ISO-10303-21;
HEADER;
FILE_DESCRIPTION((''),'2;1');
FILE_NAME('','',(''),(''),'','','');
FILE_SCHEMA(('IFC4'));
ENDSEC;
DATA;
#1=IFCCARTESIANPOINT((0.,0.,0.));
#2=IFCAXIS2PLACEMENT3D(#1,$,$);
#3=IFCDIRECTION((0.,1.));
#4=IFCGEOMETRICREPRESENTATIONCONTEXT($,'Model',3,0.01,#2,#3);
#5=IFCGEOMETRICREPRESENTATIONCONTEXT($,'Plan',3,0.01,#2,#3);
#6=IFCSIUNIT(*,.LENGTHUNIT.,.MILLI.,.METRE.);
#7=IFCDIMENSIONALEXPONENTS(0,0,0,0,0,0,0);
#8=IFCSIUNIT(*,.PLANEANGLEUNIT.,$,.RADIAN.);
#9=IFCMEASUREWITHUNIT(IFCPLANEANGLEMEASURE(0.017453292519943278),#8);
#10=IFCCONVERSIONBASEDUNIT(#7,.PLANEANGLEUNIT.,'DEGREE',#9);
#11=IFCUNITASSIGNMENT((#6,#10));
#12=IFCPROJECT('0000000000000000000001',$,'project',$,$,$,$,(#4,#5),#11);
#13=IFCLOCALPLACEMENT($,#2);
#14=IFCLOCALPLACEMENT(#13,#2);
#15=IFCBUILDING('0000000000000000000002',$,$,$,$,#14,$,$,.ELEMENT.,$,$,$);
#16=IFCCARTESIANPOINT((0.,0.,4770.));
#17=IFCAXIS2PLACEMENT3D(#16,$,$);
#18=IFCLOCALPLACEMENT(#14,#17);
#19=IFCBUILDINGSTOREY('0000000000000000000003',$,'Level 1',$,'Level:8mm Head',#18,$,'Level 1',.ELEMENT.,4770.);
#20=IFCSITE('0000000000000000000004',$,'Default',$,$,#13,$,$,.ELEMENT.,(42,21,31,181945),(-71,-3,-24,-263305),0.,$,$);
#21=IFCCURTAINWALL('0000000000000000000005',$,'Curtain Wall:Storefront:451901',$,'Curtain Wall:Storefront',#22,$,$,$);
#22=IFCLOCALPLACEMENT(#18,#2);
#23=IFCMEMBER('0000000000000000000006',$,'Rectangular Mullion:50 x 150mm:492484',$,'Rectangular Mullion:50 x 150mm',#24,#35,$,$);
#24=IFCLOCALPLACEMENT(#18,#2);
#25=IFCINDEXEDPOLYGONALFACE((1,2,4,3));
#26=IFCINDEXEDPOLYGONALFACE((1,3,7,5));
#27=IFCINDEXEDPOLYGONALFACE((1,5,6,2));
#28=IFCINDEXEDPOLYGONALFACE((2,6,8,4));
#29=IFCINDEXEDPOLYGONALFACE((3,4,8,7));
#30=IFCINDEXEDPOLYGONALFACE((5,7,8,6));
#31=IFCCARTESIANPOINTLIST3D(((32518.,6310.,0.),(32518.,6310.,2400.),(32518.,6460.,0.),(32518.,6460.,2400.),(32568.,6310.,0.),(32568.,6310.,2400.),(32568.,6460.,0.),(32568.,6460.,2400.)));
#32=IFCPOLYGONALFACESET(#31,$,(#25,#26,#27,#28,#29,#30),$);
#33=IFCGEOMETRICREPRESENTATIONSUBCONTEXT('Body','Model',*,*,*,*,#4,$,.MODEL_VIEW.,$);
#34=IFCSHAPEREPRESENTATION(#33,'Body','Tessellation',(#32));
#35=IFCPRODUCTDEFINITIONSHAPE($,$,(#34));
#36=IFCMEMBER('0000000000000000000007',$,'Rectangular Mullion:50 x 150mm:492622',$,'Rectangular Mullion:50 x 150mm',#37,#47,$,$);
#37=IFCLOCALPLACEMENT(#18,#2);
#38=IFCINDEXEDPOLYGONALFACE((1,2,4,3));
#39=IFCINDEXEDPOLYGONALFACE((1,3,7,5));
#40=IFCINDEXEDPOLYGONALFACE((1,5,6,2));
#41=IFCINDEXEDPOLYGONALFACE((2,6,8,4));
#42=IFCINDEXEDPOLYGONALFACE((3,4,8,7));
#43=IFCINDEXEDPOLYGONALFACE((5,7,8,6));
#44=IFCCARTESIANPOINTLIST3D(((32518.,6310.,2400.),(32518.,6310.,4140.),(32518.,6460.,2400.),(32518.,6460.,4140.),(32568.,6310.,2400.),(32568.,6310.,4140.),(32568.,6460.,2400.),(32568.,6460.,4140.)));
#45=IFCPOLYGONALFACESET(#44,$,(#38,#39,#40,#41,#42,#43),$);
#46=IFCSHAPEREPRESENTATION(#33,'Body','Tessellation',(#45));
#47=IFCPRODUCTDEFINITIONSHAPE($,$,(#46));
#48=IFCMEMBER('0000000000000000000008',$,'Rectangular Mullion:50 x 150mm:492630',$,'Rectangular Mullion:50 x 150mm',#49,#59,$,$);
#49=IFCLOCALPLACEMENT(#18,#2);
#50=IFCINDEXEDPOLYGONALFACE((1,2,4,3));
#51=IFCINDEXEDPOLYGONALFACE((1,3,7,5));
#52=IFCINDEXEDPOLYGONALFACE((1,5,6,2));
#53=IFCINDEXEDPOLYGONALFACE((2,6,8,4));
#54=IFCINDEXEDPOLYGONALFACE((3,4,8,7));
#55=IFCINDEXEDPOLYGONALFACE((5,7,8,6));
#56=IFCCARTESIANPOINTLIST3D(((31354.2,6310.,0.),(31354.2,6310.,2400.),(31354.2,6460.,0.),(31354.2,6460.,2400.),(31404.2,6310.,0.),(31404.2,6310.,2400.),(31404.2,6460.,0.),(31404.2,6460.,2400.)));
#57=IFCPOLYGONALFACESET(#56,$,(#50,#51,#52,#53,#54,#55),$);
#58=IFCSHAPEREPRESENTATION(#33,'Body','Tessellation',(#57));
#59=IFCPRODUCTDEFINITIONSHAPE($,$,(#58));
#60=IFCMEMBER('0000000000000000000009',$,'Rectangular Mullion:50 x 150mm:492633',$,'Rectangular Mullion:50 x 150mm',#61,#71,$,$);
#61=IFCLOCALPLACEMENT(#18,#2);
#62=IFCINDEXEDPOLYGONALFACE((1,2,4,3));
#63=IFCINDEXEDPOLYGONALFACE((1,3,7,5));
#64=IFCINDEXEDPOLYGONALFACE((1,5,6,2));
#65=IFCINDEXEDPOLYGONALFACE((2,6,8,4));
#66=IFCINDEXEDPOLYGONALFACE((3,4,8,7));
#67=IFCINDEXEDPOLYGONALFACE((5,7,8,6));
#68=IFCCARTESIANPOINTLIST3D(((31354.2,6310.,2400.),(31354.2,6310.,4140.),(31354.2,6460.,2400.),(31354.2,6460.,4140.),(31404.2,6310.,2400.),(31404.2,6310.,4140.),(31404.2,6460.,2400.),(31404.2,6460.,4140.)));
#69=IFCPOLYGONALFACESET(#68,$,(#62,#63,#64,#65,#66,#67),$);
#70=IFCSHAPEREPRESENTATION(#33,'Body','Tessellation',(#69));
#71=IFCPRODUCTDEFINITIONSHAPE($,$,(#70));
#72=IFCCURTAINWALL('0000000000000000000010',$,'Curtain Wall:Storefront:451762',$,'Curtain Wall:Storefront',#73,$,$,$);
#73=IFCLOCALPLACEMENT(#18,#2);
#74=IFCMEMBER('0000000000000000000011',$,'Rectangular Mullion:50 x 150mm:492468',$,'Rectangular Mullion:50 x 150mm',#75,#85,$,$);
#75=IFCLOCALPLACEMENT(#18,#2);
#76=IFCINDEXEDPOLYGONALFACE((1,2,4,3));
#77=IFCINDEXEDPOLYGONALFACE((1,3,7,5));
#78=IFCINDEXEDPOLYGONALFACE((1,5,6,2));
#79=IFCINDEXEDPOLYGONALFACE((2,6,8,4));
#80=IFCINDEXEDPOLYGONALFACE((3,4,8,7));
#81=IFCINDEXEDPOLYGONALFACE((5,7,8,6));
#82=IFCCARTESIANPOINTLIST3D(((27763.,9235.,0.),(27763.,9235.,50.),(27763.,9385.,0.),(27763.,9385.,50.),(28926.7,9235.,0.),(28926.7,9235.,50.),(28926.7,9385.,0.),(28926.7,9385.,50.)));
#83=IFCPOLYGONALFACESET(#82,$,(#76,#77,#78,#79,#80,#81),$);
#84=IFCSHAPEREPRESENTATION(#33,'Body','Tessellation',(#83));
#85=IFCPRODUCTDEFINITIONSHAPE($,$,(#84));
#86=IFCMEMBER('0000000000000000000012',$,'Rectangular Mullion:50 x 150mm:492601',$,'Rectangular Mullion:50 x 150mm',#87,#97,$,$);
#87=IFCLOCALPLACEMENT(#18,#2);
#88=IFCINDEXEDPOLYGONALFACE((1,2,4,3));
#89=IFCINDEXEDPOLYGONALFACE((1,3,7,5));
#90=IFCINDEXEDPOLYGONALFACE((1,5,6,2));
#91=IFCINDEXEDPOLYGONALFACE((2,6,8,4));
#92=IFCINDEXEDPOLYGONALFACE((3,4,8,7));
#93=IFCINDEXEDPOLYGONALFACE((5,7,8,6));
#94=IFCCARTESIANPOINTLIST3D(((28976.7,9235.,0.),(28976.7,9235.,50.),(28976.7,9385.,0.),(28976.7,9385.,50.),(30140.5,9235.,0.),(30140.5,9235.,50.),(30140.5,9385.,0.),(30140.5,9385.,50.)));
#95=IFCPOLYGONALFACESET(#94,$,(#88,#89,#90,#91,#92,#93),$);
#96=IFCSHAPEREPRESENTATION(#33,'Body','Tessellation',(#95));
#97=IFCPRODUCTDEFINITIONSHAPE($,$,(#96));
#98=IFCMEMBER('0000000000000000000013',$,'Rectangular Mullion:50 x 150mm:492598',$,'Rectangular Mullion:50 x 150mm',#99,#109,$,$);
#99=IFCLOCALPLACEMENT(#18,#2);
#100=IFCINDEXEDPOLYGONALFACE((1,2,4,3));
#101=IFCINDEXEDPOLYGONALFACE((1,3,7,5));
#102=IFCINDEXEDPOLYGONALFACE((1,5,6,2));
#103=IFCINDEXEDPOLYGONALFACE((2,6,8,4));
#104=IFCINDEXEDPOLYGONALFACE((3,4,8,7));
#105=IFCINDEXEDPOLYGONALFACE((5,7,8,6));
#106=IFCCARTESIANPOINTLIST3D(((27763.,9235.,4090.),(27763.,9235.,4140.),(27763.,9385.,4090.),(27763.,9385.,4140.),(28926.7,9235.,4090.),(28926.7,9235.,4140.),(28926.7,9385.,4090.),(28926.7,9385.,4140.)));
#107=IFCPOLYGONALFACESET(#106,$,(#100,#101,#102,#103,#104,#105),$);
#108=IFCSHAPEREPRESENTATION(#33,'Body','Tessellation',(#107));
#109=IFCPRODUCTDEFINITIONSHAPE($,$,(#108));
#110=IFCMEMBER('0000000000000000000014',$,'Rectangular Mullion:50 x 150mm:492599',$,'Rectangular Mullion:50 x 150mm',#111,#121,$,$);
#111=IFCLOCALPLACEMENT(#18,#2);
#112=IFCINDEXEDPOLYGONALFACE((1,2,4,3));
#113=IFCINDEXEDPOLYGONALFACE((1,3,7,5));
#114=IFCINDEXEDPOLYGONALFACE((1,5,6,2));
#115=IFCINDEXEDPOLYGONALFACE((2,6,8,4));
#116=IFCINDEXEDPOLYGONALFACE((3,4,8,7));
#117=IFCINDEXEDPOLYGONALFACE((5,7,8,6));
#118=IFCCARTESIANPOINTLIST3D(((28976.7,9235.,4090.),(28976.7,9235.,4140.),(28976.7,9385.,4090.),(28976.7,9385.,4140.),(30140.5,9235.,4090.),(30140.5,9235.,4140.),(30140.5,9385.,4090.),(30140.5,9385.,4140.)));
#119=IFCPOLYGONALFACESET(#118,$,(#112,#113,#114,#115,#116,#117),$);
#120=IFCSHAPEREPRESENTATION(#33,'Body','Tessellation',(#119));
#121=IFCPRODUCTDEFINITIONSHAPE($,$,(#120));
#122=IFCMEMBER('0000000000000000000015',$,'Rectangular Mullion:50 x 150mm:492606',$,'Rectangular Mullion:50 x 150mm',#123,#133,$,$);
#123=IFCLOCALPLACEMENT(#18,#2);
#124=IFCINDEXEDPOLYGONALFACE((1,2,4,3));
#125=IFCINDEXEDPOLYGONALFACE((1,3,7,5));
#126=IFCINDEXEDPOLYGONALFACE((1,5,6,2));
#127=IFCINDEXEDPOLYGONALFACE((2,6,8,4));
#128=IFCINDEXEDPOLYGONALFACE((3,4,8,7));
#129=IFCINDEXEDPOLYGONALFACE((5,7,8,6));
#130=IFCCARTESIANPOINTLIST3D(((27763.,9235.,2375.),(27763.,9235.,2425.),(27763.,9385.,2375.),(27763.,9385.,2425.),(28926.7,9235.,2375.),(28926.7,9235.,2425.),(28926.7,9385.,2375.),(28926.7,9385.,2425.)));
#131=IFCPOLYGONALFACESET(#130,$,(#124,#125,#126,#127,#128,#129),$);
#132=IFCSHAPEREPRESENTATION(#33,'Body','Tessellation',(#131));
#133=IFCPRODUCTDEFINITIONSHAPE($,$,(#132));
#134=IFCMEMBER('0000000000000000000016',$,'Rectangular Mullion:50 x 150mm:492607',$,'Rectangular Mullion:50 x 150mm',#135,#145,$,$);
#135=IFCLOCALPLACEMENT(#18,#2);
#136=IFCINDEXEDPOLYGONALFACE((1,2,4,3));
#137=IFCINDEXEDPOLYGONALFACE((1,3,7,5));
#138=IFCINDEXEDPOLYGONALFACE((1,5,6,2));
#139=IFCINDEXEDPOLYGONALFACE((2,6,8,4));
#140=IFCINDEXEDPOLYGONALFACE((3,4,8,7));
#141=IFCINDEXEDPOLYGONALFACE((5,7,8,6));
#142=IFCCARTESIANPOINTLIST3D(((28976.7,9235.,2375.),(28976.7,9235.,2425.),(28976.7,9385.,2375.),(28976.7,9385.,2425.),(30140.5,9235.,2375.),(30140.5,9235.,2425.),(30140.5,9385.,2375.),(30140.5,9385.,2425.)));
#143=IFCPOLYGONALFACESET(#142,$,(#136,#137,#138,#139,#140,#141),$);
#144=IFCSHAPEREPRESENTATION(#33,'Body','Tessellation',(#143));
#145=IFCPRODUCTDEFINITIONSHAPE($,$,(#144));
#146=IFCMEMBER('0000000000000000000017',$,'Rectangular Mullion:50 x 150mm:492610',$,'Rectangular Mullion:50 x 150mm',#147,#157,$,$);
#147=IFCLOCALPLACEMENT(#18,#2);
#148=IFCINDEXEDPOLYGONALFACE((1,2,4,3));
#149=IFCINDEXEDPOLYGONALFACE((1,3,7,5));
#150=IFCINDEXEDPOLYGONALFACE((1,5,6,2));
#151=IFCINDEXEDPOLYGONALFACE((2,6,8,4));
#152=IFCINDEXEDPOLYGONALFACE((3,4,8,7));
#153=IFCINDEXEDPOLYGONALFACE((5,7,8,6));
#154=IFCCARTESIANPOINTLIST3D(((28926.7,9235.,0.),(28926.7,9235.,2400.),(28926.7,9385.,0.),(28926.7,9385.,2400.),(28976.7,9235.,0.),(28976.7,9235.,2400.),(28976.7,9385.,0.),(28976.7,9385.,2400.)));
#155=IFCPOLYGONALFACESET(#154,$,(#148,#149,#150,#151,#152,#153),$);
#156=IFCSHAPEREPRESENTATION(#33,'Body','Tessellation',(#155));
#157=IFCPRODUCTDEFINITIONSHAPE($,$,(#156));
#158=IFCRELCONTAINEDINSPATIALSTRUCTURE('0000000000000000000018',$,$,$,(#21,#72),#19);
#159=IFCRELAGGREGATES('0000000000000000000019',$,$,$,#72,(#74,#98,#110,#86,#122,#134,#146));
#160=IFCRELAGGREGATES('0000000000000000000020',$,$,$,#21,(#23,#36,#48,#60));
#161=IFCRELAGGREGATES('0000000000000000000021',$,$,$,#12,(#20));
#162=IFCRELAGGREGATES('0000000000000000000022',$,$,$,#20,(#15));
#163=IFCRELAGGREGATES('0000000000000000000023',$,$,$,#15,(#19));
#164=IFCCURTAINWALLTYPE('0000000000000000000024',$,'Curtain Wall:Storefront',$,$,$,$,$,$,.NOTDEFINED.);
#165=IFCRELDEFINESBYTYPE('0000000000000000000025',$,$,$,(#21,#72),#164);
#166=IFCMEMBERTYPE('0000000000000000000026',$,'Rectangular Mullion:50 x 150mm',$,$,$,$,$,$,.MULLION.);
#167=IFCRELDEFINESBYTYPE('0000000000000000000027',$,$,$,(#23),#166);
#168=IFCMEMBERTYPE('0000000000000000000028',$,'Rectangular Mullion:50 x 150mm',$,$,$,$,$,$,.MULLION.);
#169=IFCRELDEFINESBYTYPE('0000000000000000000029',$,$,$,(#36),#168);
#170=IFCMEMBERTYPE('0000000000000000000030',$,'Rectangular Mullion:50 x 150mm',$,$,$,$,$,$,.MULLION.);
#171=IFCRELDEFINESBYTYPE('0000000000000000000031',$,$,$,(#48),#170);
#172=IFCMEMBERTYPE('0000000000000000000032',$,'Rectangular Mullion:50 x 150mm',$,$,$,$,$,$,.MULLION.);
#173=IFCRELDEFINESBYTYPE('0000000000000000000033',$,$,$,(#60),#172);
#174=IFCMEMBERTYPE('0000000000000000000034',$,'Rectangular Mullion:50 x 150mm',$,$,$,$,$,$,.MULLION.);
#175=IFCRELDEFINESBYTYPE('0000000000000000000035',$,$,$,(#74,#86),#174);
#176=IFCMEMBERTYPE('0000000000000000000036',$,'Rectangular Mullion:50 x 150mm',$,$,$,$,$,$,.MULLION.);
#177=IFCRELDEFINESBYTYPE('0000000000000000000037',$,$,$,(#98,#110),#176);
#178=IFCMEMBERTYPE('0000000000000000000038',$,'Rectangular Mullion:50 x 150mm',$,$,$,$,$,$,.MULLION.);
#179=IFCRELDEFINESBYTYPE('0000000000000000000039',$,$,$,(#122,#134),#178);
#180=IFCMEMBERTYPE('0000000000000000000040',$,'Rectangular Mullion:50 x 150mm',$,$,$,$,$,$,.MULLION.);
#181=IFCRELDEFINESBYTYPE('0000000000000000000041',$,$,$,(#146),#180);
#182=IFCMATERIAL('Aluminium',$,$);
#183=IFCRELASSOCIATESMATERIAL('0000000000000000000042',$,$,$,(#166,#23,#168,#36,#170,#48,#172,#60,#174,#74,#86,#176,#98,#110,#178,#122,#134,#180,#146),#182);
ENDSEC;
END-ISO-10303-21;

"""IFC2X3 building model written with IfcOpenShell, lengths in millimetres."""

from ifc_helpers import new_model, entity, si_unit, converted_unit, direction, frame, origin, origin_2d_with_axis, place, context, subcontext, project, spatial, rectangle, extrude, source, transform, mapped, material, type_object, type_shapes, element, aggregate, save


model = new_model("IFC2X3")

# Units and contexts
model_context = context("Model", 3, precision=0.01, world=origin(), true_north=direction((0.0, 1.0)))
plan_context = context("Plan", 3, precision=0.01, world=origin(), true_north=direction((0.0, 1.0)))
body_context = subcontext(model_context, "Body", "Model", "MODEL_VIEW")
ifc_project = project(units=[si_unit("LENGTHUNIT", "METRE", prefix="MILLI"), converted_unit("PLANEANGLEUNIT", "DEGREE", entity("IfcPlaneAngleMeasure", 0.017453292519943278), si_unit("PLANEANGLEUNIT", "RADIAN"), dimensions=[0, 0, 0, 0, 0, 0, 0])], contexts=[model_context, plan_context])

# Site, building, storey
site_placement = place(None, origin())
site = spatial("IfcSite", under=ifc_project, at=site_placement, Name="Default", CompositionType="ELEMENT", RefLatitude=(42, 21, 31, 181945), RefLongitude=(-71, -3, -24, -263305), RefElevation=0.0)
building_placement = place(site_placement, origin())
building = spatial("IfcBuilding", under=site, at=building_placement, CompositionType="ELEMENT")
storey_placement = place(building_placement, frame((0.0, 0.0, 4770.0)))
storey = spatial("IfcBuildingStorey", under=building, at=storey_placement, Name="Level 1", ObjectType="Level:8mm Head", LongName="Level 1", CompositionType="ELEMENT", Elevation=4770.0)

# Curtain walls, members
curtain_wall_type = type_object("IfcCurtainWallType", Name="Curtain Wall:Storefront", PredefinedType="NOTDEFINED")
curtain_wall_1_placement = place(storey_placement, frame((0.0, 0.0, -4770.0)))
curtain_wall_1 = element("IfcCurtainWall", 1, at=curtain_wall_1_placement, inside=storey, type_object=curtain_wall_type, Name="Curtain Wall:Storefront:451901", ObjectType="Curtain Wall:Storefront")
ifc_material_1 = material(Name="Aluminium")
member_type_1 = type_object("IfcMemberType", Name="Rectangular Mullion:50 x 150mm", PredefinedType="MULLION", material=ifc_material_1)
shared_shape_1 = source(origin(), body_context, "Body", "SweptSolid", [
    extrude(rectangle(XDim=50.0, YDim=150.0, at=origin_2d_with_axis()), frame((-25.0, 0.0, -2400.0), z_axis=(0.0, 0.0, 1.0), x_axis=(-1.0, 0.0, 0.0)), (0.0, 0.0, 1.0), 2400.0),
])
type_shapes(member_type_1, [shared_shape_1])
member_1_placement = place(curtain_wall_1_placement, frame((32568.0, 6385.0, 4770.0), z_axis=(0.0, 0.0, -1.0), x_axis=(1.0, 0.0, 0.0)))
member_1 = element("IfcMember", 2, at=member_1_placement, type_object=member_type_1, material=ifc_material_1, Name="Rectangular Mullion:50 x 150mm:492484", ObjectType="Rectangular Mullion:50 x 150mm", context=body_context, shape_type="MappedRepresentation", body=[
    mapped(shared_shape_1, transform((0.0, 0.0, 0.0), scale=1.0)),
])
member_type_2 = type_object("IfcMemberType", Name="Rectangular Mullion:50 x 150mm", PredefinedType="MULLION", material=ifc_material_1)
shared_shape_2 = source(origin(), body_context, "Body", "SweptSolid", [
    extrude(rectangle(XDim=50.0, YDim=150.0, at=origin_2d_with_axis()), frame((-25.0, 0.0, -1740.0), z_axis=(0.0, 0.0, 1.0), x_axis=(-1.0, 0.0, 0.0)), (0.0, 0.0, 1.0), 1740.0),
])
type_shapes(member_type_2, [shared_shape_2])
member_2_placement = place(curtain_wall_1_placement, frame((32568.0, 6385.0, 7170.0), z_axis=(0.0, 0.0, -1.0), x_axis=(1.0, 0.0, 0.0)))
member_2 = element("IfcMember", 3, at=member_2_placement, type_object=member_type_2, material=ifc_material_1, Name="Rectangular Mullion:50 x 150mm:492622", ObjectType="Rectangular Mullion:50 x 150mm", context=body_context, shape_type="MappedRepresentation", body=[
    mapped(shared_shape_2, transform((0.0, 0.0, 0.0), scale=1.0)),
])
member_type_3 = type_object("IfcMemberType", Name="Rectangular Mullion:50 x 150mm", PredefinedType="MULLION", material=ifc_material_1)
shared_shape_3 = source(origin(), body_context, "Body", "SweptSolid", [
    extrude(rectangle(XDim=50.0, YDim=150.0, at=origin_2d_with_axis()), frame((0.0, 0.0, -2400.0), z_axis=(0.0, 0.0, 1.0), x_axis=(-1.0, 0.0, 0.0)), (0.0, 0.0, 1.0), 2400.0),
])
type_shapes(member_type_3, [shared_shape_3])
member_3_placement = place(curtain_wall_1_placement, frame((31379.2, 6385.0, 4770.0), z_axis=(0.0, 0.0, -1.0), x_axis=(1.0, 0.0, 0.0)))
member_3 = element("IfcMember", 4, at=member_3_placement, type_object=member_type_3, material=ifc_material_1, Name="Rectangular Mullion:50 x 150mm:492630", ObjectType="Rectangular Mullion:50 x 150mm", context=body_context, shape_type="MappedRepresentation", body=[
    mapped(shared_shape_3, transform((0.0, 0.0, 0.0), scale=1.0)),
])
member_type_4 = type_object("IfcMemberType", Name="Rectangular Mullion:50 x 150mm", PredefinedType="MULLION", material=ifc_material_1)
shared_shape_4 = source(origin(), body_context, "Body", "SweptSolid", [
    extrude(rectangle(XDim=50.0, YDim=150.0, at=origin_2d_with_axis()), frame((0.0, 0.0, -1740.0), z_axis=(0.0, 0.0, 1.0), x_axis=(-1.0, 0.0, 0.0)), (0.0, 0.0, 1.0), 1740.0),
])
type_shapes(member_type_4, [shared_shape_4])
member_4_placement = place(curtain_wall_1_placement, frame((31379.2, 6385.0, 7170.0), z_axis=(0.0, 0.0, -1.0), x_axis=(1.0, 0.0, 0.0)))
member_4 = element("IfcMember", 5, at=member_4_placement, type_object=member_type_4, material=ifc_material_1, Name="Rectangular Mullion:50 x 150mm:492633", ObjectType="Rectangular Mullion:50 x 150mm", context=body_context, shape_type="MappedRepresentation", body=[
    mapped(shared_shape_4, transform((0.0, 0.0, 0.0), scale=1.0)),
])
curtain_wall_2_placement = place(storey_placement, frame((0.0, 0.0, -4770.0)))
curtain_wall_2 = element("IfcCurtainWall", 6, at=curtain_wall_2_placement, inside=storey, type_object=curtain_wall_type, Name="Curtain Wall:Storefront:451762", ObjectType="Curtain Wall:Storefront")
member_type_5 = type_object("IfcMemberType", Name="Rectangular Mullion:50 x 150mm", PredefinedType="MULLION", material=ifc_material_1)
shared_shape_5 = source(origin(), body_context, "Body", "SweptSolid", [
    extrude(rectangle(XDim=50.0, YDim=150.0, at=origin_2d_with_axis()), frame((-25.0, 0.0, -1163.8), z_axis=(0.0, 0.0, 1.0), x_axis=(-1.0, 0.0, 0.0)), (0.0, 0.0, 1.0), 1163.8),
])
type_shapes(member_type_5, [shared_shape_5])
member_5_placement = place(curtain_wall_2_placement, frame((27763.0, 9310.0, 4770.0), z_axis=(-1.0, 0.0, 0.0), x_axis=(0.0, 0.0, -1.0)))
member_5 = element("IfcMember", 7, at=member_5_placement, type_object=member_type_5, material=ifc_material_1, Name="Rectangular Mullion:50 x 150mm:492468", ObjectType="Rectangular Mullion:50 x 150mm", context=body_context, shape_type="MappedRepresentation", body=[
    mapped(shared_shape_5, transform((0.0, 0.0, 0.0), scale=1.0)),
])
member_6_placement = place(curtain_wall_2_placement, frame((28976.7, 9310.0, 4770.0), z_axis=(-1.0, 0.0, 0.0), x_axis=(0.0, 0.0, -1.0)))
member_6 = element("IfcMember", 8, at=member_6_placement, type_object=member_type_5, material=ifc_material_1, Name="Rectangular Mullion:50 x 150mm:492601", ObjectType="Rectangular Mullion:50 x 150mm", context=body_context, shape_type="MappedRepresentation", body=[
    mapped(shared_shape_5, transform((0.0, 0.0, 0.0), scale=1.0)),
])
member_type_6 = type_object("IfcMemberType", Name="Rectangular Mullion:50 x 150mm", PredefinedType="MULLION", material=ifc_material_1)
shared_shape_6 = source(origin(), body_context, "Body", "SweptSolid", [
    extrude(rectangle(XDim=50.0, YDim=150.0, at=origin_2d_with_axis()), frame((-25.0, 0.0, -1163.8), z_axis=(0.0, 0.0, 1.0), x_axis=(-1.0, 0.0, 0.0)), (0.0, 0.0, 1.0), 1163.8),
])
type_shapes(member_type_6, [shared_shape_6])
member_7_placement = place(curtain_wall_2_placement, frame((28926.7, 9310.0, 8910.0), z_axis=(1.0, 0.0, 0.0), x_axis=(0.0, 0.0, 1.0)))
member_7 = element("IfcMember", 9, at=member_7_placement, type_object=member_type_6, material=ifc_material_1, Name="Rectangular Mullion:50 x 150mm:492598", ObjectType="Rectangular Mullion:50 x 150mm", context=body_context, shape_type="MappedRepresentation", body=[
    mapped(shared_shape_6, transform((0.0, 0.0, 0.0), scale=1.0)),
])
member_8_placement = place(curtain_wall_2_placement, frame((30140.5, 9310.0, 8910.0), z_axis=(1.0, 0.0, 0.0), x_axis=(0.0, 0.0, 1.0)))
member_8 = element("IfcMember", 10, at=member_8_placement, type_object=member_type_6, material=ifc_material_1, Name="Rectangular Mullion:50 x 150mm:492599", ObjectType="Rectangular Mullion:50 x 150mm", context=body_context, shape_type="MappedRepresentation", body=[
    mapped(shared_shape_6, transform((0.0, 0.0, 0.0), scale=1.0)),
])
member_type_7 = type_object("IfcMemberType", Name="Rectangular Mullion:50 x 150mm", PredefinedType="MULLION", material=ifc_material_1)
shared_shape_7 = source(origin(), body_context, "Body", "SweptSolid", [
    extrude(rectangle(XDim=50.0, YDim=150.0, at=origin_2d_with_axis()), frame((0.0, 0.0, -1163.8), z_axis=(0.0, 0.0, 1.0), x_axis=(-1.0, 0.0, 0.0)), (0.0, 0.0, 1.0), 1163.8),
])
type_shapes(member_type_7, [shared_shape_7])
member_9_placement = place(curtain_wall_2_placement, frame((28926.7, 9310.0, 7170.0), z_axis=(1.0, 0.0, 0.0), x_axis=(0.0, 0.0, 1.0)))
member_9 = element("IfcMember", 11, at=member_9_placement, type_object=member_type_7, material=ifc_material_1, Name="Rectangular Mullion:50 x 150mm:492606", ObjectType="Rectangular Mullion:50 x 150mm", context=body_context, shape_type="MappedRepresentation", body=[
    mapped(shared_shape_7, transform((0.0, 0.0, 0.0), scale=1.0)),
])
member_10_placement = place(curtain_wall_2_placement, frame((30140.5, 9310.0, 7170.0), z_axis=(1.0, 0.0, 0.0), x_axis=(0.0, 0.0, 1.0)))
member_10 = element("IfcMember", 12, at=member_10_placement, type_object=member_type_7, material=ifc_material_1, Name="Rectangular Mullion:50 x 150mm:492607", ObjectType="Rectangular Mullion:50 x 150mm", context=body_context, shape_type="MappedRepresentation", body=[
    mapped(shared_shape_7, transform((0.0, 0.0, 0.0), scale=1.0)),
])
member_type_8 = type_object("IfcMemberType", Name="Rectangular Mullion:50 x 150mm", PredefinedType="MULLION", material=ifc_material_1)
shared_shape_8 = source(origin(), body_context, "Body", "SweptSolid", [
    extrude(rectangle(XDim=50.0, YDim=150.0, at=origin_2d_with_axis()), frame((0.0, 0.0, -2400.0), z_axis=(0.0, 0.0, 1.0), x_axis=(-1.0, 0.0, 0.0)), (0.0, 0.0, 1.0), 2400.0),
])
type_shapes(member_type_8, [shared_shape_8])
member_11_placement = place(curtain_wall_2_placement, frame((28951.7, 9310.0, 4770.0), z_axis=(0.0, 0.0, -1.0), x_axis=(1.0, 0.0, 0.0)))
member_11 = element("IfcMember", 13, at=member_11_placement, type_object=member_type_8, material=ifc_material_1, Name="Rectangular Mullion:50 x 150mm:492610", ObjectType="Rectangular Mullion:50 x 150mm", context=body_context, shape_type="MappedRepresentation", body=[
    mapped(shared_shape_8, transform((0.0, 0.0, 0.0), scale=1.0)),
])

aggregate(curtain_wall_2, [member_5, member_7, member_8, member_6, member_9, member_10, member_11])
aggregate(curtain_wall_1, [member_1, member_2, member_3, member_4])

save(model, "model.ifc")
